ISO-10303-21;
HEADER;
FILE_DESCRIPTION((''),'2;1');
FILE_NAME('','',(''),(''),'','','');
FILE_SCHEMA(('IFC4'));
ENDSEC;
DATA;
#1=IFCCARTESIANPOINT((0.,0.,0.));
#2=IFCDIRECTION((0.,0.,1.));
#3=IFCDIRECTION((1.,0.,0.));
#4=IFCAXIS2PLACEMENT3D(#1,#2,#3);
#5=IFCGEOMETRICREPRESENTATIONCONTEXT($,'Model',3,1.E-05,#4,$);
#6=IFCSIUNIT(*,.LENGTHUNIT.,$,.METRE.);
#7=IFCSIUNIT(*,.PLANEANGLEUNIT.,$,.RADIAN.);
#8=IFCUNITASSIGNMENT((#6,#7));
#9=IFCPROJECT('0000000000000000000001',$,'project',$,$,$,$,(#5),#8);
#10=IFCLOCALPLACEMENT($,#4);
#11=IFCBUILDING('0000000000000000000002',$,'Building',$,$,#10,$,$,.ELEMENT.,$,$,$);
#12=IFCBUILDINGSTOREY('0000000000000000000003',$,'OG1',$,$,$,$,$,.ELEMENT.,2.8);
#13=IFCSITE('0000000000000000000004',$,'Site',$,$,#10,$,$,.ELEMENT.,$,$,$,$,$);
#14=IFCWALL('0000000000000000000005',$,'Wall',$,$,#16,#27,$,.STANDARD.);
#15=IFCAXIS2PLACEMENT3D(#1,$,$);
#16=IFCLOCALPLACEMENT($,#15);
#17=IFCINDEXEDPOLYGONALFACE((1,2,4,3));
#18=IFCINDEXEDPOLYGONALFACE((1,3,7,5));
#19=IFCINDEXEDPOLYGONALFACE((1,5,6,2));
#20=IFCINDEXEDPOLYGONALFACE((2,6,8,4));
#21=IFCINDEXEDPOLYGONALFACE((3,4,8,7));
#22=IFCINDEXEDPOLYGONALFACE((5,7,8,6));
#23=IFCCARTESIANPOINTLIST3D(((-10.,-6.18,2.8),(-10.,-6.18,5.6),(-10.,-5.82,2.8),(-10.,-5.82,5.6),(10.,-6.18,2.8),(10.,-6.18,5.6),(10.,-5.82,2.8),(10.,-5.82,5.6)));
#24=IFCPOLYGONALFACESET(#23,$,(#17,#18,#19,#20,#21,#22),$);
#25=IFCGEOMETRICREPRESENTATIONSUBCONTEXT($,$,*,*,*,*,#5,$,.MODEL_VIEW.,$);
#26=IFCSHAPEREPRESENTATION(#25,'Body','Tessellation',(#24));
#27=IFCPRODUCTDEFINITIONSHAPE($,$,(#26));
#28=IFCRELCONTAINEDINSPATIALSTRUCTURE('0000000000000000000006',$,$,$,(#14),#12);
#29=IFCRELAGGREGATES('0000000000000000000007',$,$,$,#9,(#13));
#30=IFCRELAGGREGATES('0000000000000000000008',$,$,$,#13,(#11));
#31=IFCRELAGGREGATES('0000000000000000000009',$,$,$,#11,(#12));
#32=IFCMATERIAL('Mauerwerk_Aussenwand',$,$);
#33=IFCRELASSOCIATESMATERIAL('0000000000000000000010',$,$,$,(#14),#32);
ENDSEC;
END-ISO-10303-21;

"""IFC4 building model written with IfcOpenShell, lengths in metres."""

from ifc_helpers import new_model, si_unit, frame, frame_2d, origin, origin_with_axes, place, context, subcontext, project, spatial, rectangle, extrude, material, element, save


model = new_model("IFC4")

# Units and contexts
model_context = context("Model", 3, precision=1e-05, world=origin_with_axes())
sub_context = subcontext(model_context, None, None, "MODEL_VIEW")
ifc_project = project(units=[si_unit("LENGTHUNIT", "METRE"), si_unit("PLANEANGLEUNIT", "RADIAN")], contexts=[model_context])

# Site, building, storey
placement_1 = place(None, origin_with_axes())
site = spatial("IfcSite", under=ifc_project, at=placement_1, Name="Site", CompositionType="ELEMENT")
building = spatial("IfcBuilding", under=site, at=placement_1, Name="Building", CompositionType="ELEMENT")
storey = spatial("IfcBuildingStorey", under=building, Name="OG1", CompositionType="ELEMENT", Elevation=2.8)

# Wall
ifc_material = material(Name="Mauerwerk_Aussenwand")
placement_2 = place(None, origin_with_axes())
placement_3 = place(placement_2, frame((0.0, 0.0, 2.8)))
wall_placement = place(placement_3, frame((-10.0, -6.0, 0.0), x_axis=(1.0, 0.0, 0.0)))
element("IfcWall", 1, at=wall_placement, inside=storey, material=ifc_material, Name="Wall", PredefinedType="STANDARD", context=sub_context, shape_type="SweptSolid", body=[
    extrude(rectangle(XDim=20.0, YDim=0.36, at=frame_2d((10.0, 0.0))), origin(), (0.0, 0.0, 1.0), 2.8),
])

save(model, "model.ifc")
